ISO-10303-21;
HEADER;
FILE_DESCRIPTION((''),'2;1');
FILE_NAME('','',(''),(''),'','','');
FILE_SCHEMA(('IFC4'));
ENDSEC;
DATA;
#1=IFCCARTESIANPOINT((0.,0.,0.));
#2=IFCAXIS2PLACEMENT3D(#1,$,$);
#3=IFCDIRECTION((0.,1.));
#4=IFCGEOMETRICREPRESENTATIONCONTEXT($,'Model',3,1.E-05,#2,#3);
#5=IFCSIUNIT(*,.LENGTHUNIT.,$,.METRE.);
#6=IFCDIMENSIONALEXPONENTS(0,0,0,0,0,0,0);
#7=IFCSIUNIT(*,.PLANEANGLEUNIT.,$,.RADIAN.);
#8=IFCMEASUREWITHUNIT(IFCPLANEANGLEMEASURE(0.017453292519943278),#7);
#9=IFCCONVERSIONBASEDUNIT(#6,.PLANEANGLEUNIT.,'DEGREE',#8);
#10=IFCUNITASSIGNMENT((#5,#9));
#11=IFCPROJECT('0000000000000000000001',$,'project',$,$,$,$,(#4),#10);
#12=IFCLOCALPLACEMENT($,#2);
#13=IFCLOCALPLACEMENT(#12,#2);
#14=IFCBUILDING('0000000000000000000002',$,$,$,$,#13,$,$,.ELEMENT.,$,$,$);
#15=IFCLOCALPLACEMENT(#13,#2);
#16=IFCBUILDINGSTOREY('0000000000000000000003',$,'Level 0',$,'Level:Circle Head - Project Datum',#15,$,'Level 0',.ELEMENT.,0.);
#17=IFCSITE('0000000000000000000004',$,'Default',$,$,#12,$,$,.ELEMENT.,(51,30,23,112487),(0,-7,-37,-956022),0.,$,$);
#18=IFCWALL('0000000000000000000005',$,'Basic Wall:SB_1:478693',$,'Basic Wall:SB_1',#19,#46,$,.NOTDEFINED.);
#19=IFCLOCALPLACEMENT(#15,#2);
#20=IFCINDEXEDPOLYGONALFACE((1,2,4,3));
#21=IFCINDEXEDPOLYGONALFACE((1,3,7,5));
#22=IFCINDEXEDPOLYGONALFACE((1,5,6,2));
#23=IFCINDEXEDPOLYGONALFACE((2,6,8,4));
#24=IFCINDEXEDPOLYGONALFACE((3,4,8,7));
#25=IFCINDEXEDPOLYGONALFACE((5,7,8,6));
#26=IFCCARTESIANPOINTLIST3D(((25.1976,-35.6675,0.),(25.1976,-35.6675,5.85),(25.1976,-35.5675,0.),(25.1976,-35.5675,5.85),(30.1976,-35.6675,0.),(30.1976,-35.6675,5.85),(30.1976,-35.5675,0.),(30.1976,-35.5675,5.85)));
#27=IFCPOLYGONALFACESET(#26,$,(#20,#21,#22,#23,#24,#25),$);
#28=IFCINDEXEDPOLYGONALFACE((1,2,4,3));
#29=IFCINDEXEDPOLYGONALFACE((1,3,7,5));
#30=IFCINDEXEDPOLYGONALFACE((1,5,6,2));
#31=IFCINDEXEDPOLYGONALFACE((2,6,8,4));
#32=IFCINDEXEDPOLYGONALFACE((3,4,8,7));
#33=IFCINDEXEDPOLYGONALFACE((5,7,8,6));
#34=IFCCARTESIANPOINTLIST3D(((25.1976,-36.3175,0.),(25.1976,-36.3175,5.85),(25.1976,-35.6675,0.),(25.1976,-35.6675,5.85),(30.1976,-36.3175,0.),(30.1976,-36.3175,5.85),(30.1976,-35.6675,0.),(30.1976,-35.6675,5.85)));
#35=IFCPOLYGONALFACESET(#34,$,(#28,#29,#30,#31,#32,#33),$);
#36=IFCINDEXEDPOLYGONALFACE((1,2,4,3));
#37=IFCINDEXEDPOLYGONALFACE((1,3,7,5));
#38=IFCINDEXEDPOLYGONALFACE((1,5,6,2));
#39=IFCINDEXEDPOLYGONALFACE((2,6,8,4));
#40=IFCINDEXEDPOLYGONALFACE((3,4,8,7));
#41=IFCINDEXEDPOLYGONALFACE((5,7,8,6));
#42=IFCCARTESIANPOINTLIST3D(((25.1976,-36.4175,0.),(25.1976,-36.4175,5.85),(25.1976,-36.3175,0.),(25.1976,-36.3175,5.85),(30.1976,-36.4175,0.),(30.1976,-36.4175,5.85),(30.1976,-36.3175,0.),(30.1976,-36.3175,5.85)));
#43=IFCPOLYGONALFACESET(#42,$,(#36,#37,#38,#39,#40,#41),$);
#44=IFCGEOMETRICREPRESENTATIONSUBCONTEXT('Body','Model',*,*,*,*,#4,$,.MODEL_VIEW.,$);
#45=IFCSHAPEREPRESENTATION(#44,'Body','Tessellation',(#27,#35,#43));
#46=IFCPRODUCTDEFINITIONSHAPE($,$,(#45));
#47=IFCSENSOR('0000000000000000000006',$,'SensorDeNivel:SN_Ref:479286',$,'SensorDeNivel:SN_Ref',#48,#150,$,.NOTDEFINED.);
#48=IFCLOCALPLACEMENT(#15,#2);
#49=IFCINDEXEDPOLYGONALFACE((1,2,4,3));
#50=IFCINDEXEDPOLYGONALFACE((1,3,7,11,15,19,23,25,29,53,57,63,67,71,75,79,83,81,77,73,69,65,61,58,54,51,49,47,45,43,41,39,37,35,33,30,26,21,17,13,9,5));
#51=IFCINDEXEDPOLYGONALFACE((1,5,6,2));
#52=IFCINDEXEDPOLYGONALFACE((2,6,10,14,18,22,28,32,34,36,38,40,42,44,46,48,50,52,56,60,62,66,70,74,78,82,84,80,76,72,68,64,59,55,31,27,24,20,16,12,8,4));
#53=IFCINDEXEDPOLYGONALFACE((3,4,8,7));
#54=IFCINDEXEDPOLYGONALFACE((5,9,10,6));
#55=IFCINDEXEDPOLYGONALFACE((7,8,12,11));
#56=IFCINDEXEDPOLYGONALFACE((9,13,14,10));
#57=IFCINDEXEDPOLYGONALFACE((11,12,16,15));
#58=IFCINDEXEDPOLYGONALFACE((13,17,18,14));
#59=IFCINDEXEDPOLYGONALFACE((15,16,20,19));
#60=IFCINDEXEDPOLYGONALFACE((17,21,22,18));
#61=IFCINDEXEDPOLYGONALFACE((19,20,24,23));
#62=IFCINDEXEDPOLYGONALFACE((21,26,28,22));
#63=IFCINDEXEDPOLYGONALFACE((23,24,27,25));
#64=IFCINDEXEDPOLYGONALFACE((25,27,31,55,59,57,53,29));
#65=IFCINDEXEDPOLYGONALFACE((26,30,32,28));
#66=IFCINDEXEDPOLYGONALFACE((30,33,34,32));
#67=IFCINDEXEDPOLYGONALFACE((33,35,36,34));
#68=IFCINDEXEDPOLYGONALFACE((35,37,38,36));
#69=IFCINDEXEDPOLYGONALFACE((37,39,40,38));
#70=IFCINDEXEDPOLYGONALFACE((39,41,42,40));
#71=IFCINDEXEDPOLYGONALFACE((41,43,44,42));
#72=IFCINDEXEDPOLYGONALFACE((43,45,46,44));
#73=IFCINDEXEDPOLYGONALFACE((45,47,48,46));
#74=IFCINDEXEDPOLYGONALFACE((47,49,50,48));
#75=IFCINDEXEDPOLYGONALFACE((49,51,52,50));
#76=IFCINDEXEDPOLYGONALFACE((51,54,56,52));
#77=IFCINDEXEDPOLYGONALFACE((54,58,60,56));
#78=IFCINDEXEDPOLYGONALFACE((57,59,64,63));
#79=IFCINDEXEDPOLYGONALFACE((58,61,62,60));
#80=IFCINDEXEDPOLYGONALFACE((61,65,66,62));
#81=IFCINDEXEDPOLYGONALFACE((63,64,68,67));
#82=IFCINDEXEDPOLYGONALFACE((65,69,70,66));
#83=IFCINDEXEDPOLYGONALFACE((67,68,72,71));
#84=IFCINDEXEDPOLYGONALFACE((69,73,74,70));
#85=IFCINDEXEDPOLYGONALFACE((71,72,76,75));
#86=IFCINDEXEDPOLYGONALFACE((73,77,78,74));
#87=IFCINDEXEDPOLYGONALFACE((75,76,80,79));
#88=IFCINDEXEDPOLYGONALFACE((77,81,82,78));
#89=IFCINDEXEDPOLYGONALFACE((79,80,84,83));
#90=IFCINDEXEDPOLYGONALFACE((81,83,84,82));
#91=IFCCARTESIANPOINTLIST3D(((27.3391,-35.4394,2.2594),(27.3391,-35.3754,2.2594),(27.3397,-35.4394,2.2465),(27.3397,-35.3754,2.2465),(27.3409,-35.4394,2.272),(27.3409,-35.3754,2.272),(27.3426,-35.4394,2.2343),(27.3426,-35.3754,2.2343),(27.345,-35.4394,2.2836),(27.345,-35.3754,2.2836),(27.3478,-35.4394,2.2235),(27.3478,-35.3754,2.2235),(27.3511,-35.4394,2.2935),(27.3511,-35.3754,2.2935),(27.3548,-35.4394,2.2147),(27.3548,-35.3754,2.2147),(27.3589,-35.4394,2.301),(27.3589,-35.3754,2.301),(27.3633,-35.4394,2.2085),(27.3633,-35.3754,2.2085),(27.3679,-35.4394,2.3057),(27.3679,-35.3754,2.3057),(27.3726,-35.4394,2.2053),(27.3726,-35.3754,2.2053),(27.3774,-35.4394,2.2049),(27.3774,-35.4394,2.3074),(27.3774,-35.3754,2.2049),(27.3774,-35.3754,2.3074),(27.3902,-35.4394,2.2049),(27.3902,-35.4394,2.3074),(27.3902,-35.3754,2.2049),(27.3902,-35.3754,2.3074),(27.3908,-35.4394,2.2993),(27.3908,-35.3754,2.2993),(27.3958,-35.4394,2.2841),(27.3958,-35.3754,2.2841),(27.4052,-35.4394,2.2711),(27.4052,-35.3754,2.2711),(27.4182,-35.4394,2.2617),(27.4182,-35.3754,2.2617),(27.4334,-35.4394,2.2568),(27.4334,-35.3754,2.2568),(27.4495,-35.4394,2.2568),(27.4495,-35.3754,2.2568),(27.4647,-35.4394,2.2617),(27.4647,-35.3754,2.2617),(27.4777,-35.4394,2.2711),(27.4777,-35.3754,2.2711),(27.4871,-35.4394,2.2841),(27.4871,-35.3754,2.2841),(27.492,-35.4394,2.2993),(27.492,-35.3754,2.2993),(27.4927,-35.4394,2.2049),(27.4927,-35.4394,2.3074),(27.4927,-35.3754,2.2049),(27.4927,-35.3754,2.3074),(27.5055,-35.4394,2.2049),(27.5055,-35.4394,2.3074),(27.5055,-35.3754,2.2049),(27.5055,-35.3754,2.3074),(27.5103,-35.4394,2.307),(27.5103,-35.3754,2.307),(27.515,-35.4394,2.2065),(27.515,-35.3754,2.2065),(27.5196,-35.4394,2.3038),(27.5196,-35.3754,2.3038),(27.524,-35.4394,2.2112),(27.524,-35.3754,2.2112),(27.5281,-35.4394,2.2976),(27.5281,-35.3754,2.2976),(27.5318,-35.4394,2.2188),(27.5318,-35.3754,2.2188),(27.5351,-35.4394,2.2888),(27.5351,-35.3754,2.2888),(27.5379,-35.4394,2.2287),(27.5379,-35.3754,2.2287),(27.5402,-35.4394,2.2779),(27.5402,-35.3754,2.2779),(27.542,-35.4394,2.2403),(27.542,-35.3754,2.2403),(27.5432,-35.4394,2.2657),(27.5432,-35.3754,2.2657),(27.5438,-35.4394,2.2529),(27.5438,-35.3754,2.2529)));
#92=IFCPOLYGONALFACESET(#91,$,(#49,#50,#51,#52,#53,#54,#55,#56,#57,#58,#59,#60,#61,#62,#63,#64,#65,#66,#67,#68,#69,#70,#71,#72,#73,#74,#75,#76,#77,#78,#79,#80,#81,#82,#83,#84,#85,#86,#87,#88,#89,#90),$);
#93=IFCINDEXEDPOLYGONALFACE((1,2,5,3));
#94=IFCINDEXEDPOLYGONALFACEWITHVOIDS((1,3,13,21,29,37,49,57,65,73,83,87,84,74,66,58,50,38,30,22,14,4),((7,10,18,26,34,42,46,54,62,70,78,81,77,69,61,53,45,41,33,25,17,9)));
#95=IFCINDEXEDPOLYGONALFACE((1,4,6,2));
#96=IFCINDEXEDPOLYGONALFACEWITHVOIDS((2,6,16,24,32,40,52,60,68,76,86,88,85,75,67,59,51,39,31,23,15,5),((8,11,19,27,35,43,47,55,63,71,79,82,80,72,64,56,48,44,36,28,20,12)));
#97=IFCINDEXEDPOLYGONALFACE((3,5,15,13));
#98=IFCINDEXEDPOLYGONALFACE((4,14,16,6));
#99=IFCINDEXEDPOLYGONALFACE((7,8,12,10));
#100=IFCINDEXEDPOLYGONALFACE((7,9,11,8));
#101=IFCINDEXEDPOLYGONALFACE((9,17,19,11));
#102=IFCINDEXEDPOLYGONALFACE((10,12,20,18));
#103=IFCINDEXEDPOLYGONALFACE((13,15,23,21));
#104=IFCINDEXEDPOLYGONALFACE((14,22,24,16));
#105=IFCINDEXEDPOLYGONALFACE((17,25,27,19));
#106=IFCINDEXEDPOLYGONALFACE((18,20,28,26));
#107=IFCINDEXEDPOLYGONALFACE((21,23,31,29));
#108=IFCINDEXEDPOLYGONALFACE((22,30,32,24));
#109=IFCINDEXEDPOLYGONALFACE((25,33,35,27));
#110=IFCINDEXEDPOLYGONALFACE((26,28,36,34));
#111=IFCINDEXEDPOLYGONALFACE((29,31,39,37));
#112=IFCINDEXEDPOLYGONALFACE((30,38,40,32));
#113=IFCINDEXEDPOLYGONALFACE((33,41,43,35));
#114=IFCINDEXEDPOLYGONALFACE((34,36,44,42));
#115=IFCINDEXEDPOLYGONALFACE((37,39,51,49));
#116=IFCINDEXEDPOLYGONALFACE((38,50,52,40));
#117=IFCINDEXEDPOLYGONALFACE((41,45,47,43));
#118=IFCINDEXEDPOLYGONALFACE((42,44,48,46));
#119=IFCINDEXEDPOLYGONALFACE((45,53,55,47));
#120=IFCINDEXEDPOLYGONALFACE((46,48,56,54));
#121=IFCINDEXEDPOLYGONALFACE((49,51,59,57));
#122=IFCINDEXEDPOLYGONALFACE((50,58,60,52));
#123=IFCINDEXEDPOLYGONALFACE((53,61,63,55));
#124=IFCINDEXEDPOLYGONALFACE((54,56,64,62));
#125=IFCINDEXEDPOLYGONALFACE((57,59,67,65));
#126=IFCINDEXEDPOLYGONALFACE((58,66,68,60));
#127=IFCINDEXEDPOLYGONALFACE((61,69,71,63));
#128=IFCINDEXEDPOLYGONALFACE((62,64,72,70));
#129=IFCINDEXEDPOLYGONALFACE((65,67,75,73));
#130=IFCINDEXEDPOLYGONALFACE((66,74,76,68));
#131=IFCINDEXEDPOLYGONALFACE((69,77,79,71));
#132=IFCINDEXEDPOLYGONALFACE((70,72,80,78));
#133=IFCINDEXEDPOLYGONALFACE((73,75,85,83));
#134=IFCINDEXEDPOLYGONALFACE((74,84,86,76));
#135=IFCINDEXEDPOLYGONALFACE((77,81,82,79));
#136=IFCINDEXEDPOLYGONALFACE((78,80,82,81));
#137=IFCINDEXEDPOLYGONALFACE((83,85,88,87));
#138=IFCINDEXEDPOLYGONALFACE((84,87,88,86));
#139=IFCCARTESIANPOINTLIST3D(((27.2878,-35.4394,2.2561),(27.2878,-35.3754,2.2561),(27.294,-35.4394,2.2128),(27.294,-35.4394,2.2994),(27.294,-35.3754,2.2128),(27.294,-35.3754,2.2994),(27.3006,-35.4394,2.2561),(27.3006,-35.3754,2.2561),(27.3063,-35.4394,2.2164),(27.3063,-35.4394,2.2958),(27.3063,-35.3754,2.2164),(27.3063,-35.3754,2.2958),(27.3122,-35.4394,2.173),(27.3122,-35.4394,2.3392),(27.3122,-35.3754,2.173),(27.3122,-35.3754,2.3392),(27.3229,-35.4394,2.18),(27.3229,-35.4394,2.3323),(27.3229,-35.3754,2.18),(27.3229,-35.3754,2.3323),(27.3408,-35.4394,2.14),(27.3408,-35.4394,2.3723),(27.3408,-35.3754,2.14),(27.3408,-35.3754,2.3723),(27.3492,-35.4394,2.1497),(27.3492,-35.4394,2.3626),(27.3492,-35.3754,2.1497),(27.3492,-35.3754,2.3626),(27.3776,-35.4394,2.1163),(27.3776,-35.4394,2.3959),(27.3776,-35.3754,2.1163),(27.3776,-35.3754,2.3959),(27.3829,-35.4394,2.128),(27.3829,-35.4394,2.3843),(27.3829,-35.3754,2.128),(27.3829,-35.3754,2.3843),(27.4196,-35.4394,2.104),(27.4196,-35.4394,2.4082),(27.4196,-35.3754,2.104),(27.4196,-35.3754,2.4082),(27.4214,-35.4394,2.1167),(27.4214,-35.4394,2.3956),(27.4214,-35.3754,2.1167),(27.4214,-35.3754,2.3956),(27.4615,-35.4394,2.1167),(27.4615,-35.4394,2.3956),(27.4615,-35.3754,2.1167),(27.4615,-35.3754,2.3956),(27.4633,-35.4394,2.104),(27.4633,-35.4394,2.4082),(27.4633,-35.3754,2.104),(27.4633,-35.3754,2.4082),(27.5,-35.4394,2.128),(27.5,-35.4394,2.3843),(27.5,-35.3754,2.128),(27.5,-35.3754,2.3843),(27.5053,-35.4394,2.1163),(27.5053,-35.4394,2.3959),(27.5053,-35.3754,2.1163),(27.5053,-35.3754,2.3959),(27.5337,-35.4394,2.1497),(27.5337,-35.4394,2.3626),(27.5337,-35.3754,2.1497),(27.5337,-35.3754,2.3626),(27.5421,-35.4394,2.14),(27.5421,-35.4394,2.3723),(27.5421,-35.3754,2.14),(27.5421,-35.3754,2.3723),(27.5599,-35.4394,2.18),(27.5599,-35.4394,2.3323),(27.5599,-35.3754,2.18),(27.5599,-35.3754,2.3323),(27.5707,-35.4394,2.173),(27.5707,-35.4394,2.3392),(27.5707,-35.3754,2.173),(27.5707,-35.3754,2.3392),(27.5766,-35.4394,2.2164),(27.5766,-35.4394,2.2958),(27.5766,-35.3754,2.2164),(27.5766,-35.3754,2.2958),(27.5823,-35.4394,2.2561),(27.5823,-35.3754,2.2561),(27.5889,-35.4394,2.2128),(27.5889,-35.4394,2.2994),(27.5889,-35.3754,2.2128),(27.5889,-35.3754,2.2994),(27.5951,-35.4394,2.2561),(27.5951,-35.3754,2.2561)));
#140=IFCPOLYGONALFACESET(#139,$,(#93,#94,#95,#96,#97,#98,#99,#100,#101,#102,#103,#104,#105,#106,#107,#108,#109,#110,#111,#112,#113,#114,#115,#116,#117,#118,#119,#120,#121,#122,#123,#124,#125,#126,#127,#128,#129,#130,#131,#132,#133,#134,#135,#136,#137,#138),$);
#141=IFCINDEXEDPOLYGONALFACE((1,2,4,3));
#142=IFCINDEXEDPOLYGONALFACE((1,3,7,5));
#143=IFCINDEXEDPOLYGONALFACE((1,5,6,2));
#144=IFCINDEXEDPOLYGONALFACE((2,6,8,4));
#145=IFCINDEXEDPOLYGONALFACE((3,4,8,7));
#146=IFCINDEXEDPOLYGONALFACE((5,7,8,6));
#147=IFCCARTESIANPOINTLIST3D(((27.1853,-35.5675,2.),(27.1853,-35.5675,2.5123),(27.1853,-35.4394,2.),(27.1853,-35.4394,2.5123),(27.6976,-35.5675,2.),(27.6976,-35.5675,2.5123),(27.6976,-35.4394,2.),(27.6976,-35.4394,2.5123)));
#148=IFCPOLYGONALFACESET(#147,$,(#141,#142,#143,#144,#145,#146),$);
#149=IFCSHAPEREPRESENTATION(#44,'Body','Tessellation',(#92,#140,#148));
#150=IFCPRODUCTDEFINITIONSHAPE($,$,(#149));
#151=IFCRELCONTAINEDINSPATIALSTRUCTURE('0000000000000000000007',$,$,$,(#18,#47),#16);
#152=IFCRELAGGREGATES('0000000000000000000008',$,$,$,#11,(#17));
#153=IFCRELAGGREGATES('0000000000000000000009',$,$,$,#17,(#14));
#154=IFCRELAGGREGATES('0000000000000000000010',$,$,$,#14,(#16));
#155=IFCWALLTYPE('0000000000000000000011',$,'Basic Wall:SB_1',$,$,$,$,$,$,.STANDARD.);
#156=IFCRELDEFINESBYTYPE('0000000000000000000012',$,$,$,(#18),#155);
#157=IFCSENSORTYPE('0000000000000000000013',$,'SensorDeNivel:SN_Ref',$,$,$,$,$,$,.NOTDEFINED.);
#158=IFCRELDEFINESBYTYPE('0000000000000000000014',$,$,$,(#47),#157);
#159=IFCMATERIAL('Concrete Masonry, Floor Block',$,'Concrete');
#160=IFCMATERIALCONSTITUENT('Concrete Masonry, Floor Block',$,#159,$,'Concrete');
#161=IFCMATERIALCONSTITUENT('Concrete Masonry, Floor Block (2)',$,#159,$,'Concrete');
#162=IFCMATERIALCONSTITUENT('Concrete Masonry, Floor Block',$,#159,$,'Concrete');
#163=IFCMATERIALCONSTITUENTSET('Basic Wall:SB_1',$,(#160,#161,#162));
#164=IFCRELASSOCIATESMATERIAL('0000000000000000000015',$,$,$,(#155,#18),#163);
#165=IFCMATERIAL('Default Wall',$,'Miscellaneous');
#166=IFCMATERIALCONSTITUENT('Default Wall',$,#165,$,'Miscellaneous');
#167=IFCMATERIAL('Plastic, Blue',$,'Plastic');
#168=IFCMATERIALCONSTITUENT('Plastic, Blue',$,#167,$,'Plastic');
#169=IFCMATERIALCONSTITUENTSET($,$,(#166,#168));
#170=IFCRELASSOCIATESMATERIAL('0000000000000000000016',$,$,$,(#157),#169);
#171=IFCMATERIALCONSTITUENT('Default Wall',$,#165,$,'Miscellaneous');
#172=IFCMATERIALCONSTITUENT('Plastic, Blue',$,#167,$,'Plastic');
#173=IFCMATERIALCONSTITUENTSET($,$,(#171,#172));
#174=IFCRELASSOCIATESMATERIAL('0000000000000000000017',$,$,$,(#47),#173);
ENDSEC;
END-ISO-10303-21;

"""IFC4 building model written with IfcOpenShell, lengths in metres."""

from ifc_helpers import new_model, entity, si_unit, converted_unit, direction, frame, origin, place, context, subcontext, project, spatial, arc, indexed_curve, outline, extrude, source, transform, mapped, material, constituent, constituent_set, type_object, type_shapes, element, save


model = new_model("IFC4")

# Units and contexts
model_context = context("Model", 3, precision=1e-05, world=origin(), true_north=direction((0.0, 1.0)))
body_context = subcontext(model_context, "Body", "Model", "MODEL_VIEW")
ifc_project = project(units=[si_unit("LENGTHUNIT", "METRE"), converted_unit("PLANEANGLEUNIT", "DEGREE", entity("IfcPlaneAngleMeasure", 0.017453292519943278), si_unit("PLANEANGLEUNIT", "RADIAN"), dimensions=[0, 0, 0, 0, 0, 0, 0])], contexts=[model_context])

# Site, building, storey
site_placement = place(None, origin())
site = spatial("IfcSite", under=ifc_project, at=site_placement, Name="Default", CompositionType="ELEMENT", RefLatitude=(51, 30, 23, 112487), RefLongitude=(0, -7, -37, -956022), RefElevation=0.0)
building_placement = place(site_placement, origin())
building = spatial("IfcBuilding", under=site, at=building_placement, CompositionType="ELEMENT")
storey_placement = place(building_placement, origin())
storey = spatial("IfcBuildingStorey", under=building, at=storey_placement, Name="Level 0", ObjectType="Level:Circle Head - Project Datum", LongName="Level 0", CompositionType="ELEMENT", Elevation=0.0)

# Shared definitions
ifc_material_1 = material(Name="Concrete Masonry, Floor Block", Category="Concrete")
ifc_constituent_1 = constituent(ifc_material_1, Name="Concrete Masonry, Floor Block", Category="Concrete")
ifc_constituent_2 = constituent(ifc_material_1, Name="Concrete Masonry, Floor Block (2)", Category="Concrete")
ifc_constituent_3 = constituent(ifc_material_1, Name="Concrete Masonry, Floor Block", Category="Concrete")
ifc_constituent_set_1 = constituent_set(constituents=[ifc_constituent_1, ifc_constituent_2, ifc_constituent_3], Name="Basic Wall:SB_1")
wall_type = type_object("IfcWallType", Name="Basic Wall:SB_1", PredefinedType="STANDARD", material=ifc_constituent_set_1)

# Wall
wall_1_placement = place(storey_placement, frame((25.1976, -35.9925, 0.0)))
element("IfcWall", 1, at=wall_1_placement, inside=storey, type_object=wall_type, material=ifc_constituent_set_1, Name="Basic Wall:SB_1:478693", ObjectType="Basic Wall:SB_1", PredefinedType="NOTDEFINED", context=body_context, shape_type="SweptSolid", body=[
    extrude(outline(indexed_curve([(-0.05, -2.5), (0.05, -2.5), (0.05, 2.5), (-0.05, 2.5), (-0.05, -2.5)], self_intersect=False)), frame((2.5, 0.375, 0.0), z_axis=(0.0, 0.0, 1.0), x_axis=(0.0, -1.0, 0.0)), (0.0, 0.0, 1.0), 5.85),
    extrude(outline(indexed_curve([(-2.5, -0.325), (2.5, -0.325), (2.5, 0.325), (-2.5, 0.325), (-2.5, -0.325)], self_intersect=False)), frame((2.5, 0.0, 0.0)), (0.0, 0.0, 1.0), 5.85),
    extrude(outline(indexed_curve([(-0.05, -2.5), (0.05, -2.5), (0.05, 2.5), (-0.05, 2.5), (-0.05, -2.5)], self_intersect=False)), frame((2.5, -0.375, 0.0), z_axis=(0.0, 0.0, 1.0), x_axis=(0.0, 1.0, 0.0)), (0.0, 0.0, 1.0), 5.85),
])

# Sensor
ifc_material_2 = material(Name="Default Wall", Category="Miscellaneous")
ifc_constituent_4 = constituent(ifc_material_2, Name="Default Wall", Category="Miscellaneous")
ifc_material_3 = material(Name="Plastic, Blue", Category="Plastic")
ifc_constituent_5 = constituent(ifc_material_3, Name="Plastic, Blue", Category="Plastic")
ifc_constituent_set_2 = constituent_set(constituents=[ifc_constituent_4, ifc_constituent_5])
ifc_constituent_6 = constituent(ifc_material_2, Name="Default Wall", Category="Miscellaneous")
ifc_constituent_7 = constituent(ifc_material_3, Name="Plastic, Blue", Category="Plastic")
ifc_constituent_set_3 = constituent_set(constituents=[ifc_constituent_6, ifc_constituent_7])
sensor_type_1 = type_object("IfcSensorType", Name="SensorDeNivel:SN_Ref", PredefinedType="NOTDEFINED", material=ifc_constituent_set_3)
shared_shape_1 = source(origin(), body_context, "Body", "SweptSolid", [
    extrude(outline(indexed_curve([(0.0512, -0.0556), (0.064, -0.0556), (0.0736, -0.054), (0.0825, -0.0493), (0.0903, -0.0417), (0.0965, -0.0318), (0.1006, -0.0202), (0.1024, -0.0076), (0.1018, 0.0052), (0.0988, 0.0174), (0.0936, 0.0283), (0.0866, 0.037), (0.0782, 0.0432), (0.0689, 0.0464), (0.064, 0.0468), (0.0512, 0.0468), (0.0506, 0.0388), (0.0456, 0.0236), (0.0362, 0.0106), (0.0233, 0.0012), (0.008, -0.0038), (-0.008, -0.0038), (-0.0233, 0.0012), (-0.0362, 0.0106), (-0.0456, 0.0236), (-0.0506, 0.0388), (-0.0512, 0.0468), (-0.064, 0.0468), (-0.0736, 0.0452), (-0.0825, 0.0405), (-0.0903, 0.0329), (-0.0965, 0.023), (-0.1006, 0.0114), (-0.1024, -0.0012), (-0.1018, -0.014), (-0.0988, -0.0262), (-0.0936, -0.0371), (-0.0866, -0.0458), (-0.0782, -0.052), (-0.0689, -0.0552), (-0.064, -0.0556), (-0.0512, -0.0556), (0.0512, -0.0556)], self_intersect=False)), frame((0.0, -0.1281, 0.2605), z_axis=(0.0, 1.0, 0.0), x_axis=(-1.0, 0.0, 0.0)), (0.0, 0.0, 1.0), 0.064),
    extrude(outline(indexed_curve([(-0.1537, 0.0), (0.0, -0.1537), (0.1537, 0.0), (0.0, 0.1537)], segments=[arc(1, 2, 3), arc(3, 4, 1)], self_intersect=False), holes=[indexed_curve([(-0.1409, 0.0), (0.0, 0.1409), (0.1409, 0.0), (0.0, -0.1409)], segments=[arc(1, 2, 3), arc(3, 4, 1)], self_intersect=False)]), frame((0.0, -0.1281, 0.2561), z_axis=(0.0, 1.0, 0.0), x_axis=(1.0, 0.0, 0.0)), (0.0, 0.0, 1.0), 0.064),
    extrude(outline(indexed_curve([(-0.2561, -0.064), (0.2561, -0.064), (0.2561, 0.064), (-0.2561, 0.064), (-0.2561, -0.064)], self_intersect=False)), frame((0.0, 0.0, 0.0), z_axis=(0.0, 0.0, 1.0), x_axis=(-1.0, 0.0, 0.0)), (0.0, 0.0, 1.0), 0.5123),
])
type_shapes(sensor_type_1, [shared_shape_1])
sensor_1_placement = place(storey_placement, frame((27.4414, -35.5035, 2.0), z_axis=(0.0, 0.0, 1.0), x_axis=(-1.0, 0.0, 0.0)))
element("IfcSensor", 2, at=sensor_1_placement, inside=storey, type_object=sensor_type_1, material=ifc_constituent_set_2, Name="SensorDeNivel:SN_Ref:479286", ObjectType="SensorDeNivel:SN_Ref", PredefinedType="NOTDEFINED", context=body_context, shape_type="MappedRepresentation", body=[
    mapped(shared_shape_1, transform((0.0, 0.0, 0.0), scale=1.0)),
])

save(model, "model.ifc")
